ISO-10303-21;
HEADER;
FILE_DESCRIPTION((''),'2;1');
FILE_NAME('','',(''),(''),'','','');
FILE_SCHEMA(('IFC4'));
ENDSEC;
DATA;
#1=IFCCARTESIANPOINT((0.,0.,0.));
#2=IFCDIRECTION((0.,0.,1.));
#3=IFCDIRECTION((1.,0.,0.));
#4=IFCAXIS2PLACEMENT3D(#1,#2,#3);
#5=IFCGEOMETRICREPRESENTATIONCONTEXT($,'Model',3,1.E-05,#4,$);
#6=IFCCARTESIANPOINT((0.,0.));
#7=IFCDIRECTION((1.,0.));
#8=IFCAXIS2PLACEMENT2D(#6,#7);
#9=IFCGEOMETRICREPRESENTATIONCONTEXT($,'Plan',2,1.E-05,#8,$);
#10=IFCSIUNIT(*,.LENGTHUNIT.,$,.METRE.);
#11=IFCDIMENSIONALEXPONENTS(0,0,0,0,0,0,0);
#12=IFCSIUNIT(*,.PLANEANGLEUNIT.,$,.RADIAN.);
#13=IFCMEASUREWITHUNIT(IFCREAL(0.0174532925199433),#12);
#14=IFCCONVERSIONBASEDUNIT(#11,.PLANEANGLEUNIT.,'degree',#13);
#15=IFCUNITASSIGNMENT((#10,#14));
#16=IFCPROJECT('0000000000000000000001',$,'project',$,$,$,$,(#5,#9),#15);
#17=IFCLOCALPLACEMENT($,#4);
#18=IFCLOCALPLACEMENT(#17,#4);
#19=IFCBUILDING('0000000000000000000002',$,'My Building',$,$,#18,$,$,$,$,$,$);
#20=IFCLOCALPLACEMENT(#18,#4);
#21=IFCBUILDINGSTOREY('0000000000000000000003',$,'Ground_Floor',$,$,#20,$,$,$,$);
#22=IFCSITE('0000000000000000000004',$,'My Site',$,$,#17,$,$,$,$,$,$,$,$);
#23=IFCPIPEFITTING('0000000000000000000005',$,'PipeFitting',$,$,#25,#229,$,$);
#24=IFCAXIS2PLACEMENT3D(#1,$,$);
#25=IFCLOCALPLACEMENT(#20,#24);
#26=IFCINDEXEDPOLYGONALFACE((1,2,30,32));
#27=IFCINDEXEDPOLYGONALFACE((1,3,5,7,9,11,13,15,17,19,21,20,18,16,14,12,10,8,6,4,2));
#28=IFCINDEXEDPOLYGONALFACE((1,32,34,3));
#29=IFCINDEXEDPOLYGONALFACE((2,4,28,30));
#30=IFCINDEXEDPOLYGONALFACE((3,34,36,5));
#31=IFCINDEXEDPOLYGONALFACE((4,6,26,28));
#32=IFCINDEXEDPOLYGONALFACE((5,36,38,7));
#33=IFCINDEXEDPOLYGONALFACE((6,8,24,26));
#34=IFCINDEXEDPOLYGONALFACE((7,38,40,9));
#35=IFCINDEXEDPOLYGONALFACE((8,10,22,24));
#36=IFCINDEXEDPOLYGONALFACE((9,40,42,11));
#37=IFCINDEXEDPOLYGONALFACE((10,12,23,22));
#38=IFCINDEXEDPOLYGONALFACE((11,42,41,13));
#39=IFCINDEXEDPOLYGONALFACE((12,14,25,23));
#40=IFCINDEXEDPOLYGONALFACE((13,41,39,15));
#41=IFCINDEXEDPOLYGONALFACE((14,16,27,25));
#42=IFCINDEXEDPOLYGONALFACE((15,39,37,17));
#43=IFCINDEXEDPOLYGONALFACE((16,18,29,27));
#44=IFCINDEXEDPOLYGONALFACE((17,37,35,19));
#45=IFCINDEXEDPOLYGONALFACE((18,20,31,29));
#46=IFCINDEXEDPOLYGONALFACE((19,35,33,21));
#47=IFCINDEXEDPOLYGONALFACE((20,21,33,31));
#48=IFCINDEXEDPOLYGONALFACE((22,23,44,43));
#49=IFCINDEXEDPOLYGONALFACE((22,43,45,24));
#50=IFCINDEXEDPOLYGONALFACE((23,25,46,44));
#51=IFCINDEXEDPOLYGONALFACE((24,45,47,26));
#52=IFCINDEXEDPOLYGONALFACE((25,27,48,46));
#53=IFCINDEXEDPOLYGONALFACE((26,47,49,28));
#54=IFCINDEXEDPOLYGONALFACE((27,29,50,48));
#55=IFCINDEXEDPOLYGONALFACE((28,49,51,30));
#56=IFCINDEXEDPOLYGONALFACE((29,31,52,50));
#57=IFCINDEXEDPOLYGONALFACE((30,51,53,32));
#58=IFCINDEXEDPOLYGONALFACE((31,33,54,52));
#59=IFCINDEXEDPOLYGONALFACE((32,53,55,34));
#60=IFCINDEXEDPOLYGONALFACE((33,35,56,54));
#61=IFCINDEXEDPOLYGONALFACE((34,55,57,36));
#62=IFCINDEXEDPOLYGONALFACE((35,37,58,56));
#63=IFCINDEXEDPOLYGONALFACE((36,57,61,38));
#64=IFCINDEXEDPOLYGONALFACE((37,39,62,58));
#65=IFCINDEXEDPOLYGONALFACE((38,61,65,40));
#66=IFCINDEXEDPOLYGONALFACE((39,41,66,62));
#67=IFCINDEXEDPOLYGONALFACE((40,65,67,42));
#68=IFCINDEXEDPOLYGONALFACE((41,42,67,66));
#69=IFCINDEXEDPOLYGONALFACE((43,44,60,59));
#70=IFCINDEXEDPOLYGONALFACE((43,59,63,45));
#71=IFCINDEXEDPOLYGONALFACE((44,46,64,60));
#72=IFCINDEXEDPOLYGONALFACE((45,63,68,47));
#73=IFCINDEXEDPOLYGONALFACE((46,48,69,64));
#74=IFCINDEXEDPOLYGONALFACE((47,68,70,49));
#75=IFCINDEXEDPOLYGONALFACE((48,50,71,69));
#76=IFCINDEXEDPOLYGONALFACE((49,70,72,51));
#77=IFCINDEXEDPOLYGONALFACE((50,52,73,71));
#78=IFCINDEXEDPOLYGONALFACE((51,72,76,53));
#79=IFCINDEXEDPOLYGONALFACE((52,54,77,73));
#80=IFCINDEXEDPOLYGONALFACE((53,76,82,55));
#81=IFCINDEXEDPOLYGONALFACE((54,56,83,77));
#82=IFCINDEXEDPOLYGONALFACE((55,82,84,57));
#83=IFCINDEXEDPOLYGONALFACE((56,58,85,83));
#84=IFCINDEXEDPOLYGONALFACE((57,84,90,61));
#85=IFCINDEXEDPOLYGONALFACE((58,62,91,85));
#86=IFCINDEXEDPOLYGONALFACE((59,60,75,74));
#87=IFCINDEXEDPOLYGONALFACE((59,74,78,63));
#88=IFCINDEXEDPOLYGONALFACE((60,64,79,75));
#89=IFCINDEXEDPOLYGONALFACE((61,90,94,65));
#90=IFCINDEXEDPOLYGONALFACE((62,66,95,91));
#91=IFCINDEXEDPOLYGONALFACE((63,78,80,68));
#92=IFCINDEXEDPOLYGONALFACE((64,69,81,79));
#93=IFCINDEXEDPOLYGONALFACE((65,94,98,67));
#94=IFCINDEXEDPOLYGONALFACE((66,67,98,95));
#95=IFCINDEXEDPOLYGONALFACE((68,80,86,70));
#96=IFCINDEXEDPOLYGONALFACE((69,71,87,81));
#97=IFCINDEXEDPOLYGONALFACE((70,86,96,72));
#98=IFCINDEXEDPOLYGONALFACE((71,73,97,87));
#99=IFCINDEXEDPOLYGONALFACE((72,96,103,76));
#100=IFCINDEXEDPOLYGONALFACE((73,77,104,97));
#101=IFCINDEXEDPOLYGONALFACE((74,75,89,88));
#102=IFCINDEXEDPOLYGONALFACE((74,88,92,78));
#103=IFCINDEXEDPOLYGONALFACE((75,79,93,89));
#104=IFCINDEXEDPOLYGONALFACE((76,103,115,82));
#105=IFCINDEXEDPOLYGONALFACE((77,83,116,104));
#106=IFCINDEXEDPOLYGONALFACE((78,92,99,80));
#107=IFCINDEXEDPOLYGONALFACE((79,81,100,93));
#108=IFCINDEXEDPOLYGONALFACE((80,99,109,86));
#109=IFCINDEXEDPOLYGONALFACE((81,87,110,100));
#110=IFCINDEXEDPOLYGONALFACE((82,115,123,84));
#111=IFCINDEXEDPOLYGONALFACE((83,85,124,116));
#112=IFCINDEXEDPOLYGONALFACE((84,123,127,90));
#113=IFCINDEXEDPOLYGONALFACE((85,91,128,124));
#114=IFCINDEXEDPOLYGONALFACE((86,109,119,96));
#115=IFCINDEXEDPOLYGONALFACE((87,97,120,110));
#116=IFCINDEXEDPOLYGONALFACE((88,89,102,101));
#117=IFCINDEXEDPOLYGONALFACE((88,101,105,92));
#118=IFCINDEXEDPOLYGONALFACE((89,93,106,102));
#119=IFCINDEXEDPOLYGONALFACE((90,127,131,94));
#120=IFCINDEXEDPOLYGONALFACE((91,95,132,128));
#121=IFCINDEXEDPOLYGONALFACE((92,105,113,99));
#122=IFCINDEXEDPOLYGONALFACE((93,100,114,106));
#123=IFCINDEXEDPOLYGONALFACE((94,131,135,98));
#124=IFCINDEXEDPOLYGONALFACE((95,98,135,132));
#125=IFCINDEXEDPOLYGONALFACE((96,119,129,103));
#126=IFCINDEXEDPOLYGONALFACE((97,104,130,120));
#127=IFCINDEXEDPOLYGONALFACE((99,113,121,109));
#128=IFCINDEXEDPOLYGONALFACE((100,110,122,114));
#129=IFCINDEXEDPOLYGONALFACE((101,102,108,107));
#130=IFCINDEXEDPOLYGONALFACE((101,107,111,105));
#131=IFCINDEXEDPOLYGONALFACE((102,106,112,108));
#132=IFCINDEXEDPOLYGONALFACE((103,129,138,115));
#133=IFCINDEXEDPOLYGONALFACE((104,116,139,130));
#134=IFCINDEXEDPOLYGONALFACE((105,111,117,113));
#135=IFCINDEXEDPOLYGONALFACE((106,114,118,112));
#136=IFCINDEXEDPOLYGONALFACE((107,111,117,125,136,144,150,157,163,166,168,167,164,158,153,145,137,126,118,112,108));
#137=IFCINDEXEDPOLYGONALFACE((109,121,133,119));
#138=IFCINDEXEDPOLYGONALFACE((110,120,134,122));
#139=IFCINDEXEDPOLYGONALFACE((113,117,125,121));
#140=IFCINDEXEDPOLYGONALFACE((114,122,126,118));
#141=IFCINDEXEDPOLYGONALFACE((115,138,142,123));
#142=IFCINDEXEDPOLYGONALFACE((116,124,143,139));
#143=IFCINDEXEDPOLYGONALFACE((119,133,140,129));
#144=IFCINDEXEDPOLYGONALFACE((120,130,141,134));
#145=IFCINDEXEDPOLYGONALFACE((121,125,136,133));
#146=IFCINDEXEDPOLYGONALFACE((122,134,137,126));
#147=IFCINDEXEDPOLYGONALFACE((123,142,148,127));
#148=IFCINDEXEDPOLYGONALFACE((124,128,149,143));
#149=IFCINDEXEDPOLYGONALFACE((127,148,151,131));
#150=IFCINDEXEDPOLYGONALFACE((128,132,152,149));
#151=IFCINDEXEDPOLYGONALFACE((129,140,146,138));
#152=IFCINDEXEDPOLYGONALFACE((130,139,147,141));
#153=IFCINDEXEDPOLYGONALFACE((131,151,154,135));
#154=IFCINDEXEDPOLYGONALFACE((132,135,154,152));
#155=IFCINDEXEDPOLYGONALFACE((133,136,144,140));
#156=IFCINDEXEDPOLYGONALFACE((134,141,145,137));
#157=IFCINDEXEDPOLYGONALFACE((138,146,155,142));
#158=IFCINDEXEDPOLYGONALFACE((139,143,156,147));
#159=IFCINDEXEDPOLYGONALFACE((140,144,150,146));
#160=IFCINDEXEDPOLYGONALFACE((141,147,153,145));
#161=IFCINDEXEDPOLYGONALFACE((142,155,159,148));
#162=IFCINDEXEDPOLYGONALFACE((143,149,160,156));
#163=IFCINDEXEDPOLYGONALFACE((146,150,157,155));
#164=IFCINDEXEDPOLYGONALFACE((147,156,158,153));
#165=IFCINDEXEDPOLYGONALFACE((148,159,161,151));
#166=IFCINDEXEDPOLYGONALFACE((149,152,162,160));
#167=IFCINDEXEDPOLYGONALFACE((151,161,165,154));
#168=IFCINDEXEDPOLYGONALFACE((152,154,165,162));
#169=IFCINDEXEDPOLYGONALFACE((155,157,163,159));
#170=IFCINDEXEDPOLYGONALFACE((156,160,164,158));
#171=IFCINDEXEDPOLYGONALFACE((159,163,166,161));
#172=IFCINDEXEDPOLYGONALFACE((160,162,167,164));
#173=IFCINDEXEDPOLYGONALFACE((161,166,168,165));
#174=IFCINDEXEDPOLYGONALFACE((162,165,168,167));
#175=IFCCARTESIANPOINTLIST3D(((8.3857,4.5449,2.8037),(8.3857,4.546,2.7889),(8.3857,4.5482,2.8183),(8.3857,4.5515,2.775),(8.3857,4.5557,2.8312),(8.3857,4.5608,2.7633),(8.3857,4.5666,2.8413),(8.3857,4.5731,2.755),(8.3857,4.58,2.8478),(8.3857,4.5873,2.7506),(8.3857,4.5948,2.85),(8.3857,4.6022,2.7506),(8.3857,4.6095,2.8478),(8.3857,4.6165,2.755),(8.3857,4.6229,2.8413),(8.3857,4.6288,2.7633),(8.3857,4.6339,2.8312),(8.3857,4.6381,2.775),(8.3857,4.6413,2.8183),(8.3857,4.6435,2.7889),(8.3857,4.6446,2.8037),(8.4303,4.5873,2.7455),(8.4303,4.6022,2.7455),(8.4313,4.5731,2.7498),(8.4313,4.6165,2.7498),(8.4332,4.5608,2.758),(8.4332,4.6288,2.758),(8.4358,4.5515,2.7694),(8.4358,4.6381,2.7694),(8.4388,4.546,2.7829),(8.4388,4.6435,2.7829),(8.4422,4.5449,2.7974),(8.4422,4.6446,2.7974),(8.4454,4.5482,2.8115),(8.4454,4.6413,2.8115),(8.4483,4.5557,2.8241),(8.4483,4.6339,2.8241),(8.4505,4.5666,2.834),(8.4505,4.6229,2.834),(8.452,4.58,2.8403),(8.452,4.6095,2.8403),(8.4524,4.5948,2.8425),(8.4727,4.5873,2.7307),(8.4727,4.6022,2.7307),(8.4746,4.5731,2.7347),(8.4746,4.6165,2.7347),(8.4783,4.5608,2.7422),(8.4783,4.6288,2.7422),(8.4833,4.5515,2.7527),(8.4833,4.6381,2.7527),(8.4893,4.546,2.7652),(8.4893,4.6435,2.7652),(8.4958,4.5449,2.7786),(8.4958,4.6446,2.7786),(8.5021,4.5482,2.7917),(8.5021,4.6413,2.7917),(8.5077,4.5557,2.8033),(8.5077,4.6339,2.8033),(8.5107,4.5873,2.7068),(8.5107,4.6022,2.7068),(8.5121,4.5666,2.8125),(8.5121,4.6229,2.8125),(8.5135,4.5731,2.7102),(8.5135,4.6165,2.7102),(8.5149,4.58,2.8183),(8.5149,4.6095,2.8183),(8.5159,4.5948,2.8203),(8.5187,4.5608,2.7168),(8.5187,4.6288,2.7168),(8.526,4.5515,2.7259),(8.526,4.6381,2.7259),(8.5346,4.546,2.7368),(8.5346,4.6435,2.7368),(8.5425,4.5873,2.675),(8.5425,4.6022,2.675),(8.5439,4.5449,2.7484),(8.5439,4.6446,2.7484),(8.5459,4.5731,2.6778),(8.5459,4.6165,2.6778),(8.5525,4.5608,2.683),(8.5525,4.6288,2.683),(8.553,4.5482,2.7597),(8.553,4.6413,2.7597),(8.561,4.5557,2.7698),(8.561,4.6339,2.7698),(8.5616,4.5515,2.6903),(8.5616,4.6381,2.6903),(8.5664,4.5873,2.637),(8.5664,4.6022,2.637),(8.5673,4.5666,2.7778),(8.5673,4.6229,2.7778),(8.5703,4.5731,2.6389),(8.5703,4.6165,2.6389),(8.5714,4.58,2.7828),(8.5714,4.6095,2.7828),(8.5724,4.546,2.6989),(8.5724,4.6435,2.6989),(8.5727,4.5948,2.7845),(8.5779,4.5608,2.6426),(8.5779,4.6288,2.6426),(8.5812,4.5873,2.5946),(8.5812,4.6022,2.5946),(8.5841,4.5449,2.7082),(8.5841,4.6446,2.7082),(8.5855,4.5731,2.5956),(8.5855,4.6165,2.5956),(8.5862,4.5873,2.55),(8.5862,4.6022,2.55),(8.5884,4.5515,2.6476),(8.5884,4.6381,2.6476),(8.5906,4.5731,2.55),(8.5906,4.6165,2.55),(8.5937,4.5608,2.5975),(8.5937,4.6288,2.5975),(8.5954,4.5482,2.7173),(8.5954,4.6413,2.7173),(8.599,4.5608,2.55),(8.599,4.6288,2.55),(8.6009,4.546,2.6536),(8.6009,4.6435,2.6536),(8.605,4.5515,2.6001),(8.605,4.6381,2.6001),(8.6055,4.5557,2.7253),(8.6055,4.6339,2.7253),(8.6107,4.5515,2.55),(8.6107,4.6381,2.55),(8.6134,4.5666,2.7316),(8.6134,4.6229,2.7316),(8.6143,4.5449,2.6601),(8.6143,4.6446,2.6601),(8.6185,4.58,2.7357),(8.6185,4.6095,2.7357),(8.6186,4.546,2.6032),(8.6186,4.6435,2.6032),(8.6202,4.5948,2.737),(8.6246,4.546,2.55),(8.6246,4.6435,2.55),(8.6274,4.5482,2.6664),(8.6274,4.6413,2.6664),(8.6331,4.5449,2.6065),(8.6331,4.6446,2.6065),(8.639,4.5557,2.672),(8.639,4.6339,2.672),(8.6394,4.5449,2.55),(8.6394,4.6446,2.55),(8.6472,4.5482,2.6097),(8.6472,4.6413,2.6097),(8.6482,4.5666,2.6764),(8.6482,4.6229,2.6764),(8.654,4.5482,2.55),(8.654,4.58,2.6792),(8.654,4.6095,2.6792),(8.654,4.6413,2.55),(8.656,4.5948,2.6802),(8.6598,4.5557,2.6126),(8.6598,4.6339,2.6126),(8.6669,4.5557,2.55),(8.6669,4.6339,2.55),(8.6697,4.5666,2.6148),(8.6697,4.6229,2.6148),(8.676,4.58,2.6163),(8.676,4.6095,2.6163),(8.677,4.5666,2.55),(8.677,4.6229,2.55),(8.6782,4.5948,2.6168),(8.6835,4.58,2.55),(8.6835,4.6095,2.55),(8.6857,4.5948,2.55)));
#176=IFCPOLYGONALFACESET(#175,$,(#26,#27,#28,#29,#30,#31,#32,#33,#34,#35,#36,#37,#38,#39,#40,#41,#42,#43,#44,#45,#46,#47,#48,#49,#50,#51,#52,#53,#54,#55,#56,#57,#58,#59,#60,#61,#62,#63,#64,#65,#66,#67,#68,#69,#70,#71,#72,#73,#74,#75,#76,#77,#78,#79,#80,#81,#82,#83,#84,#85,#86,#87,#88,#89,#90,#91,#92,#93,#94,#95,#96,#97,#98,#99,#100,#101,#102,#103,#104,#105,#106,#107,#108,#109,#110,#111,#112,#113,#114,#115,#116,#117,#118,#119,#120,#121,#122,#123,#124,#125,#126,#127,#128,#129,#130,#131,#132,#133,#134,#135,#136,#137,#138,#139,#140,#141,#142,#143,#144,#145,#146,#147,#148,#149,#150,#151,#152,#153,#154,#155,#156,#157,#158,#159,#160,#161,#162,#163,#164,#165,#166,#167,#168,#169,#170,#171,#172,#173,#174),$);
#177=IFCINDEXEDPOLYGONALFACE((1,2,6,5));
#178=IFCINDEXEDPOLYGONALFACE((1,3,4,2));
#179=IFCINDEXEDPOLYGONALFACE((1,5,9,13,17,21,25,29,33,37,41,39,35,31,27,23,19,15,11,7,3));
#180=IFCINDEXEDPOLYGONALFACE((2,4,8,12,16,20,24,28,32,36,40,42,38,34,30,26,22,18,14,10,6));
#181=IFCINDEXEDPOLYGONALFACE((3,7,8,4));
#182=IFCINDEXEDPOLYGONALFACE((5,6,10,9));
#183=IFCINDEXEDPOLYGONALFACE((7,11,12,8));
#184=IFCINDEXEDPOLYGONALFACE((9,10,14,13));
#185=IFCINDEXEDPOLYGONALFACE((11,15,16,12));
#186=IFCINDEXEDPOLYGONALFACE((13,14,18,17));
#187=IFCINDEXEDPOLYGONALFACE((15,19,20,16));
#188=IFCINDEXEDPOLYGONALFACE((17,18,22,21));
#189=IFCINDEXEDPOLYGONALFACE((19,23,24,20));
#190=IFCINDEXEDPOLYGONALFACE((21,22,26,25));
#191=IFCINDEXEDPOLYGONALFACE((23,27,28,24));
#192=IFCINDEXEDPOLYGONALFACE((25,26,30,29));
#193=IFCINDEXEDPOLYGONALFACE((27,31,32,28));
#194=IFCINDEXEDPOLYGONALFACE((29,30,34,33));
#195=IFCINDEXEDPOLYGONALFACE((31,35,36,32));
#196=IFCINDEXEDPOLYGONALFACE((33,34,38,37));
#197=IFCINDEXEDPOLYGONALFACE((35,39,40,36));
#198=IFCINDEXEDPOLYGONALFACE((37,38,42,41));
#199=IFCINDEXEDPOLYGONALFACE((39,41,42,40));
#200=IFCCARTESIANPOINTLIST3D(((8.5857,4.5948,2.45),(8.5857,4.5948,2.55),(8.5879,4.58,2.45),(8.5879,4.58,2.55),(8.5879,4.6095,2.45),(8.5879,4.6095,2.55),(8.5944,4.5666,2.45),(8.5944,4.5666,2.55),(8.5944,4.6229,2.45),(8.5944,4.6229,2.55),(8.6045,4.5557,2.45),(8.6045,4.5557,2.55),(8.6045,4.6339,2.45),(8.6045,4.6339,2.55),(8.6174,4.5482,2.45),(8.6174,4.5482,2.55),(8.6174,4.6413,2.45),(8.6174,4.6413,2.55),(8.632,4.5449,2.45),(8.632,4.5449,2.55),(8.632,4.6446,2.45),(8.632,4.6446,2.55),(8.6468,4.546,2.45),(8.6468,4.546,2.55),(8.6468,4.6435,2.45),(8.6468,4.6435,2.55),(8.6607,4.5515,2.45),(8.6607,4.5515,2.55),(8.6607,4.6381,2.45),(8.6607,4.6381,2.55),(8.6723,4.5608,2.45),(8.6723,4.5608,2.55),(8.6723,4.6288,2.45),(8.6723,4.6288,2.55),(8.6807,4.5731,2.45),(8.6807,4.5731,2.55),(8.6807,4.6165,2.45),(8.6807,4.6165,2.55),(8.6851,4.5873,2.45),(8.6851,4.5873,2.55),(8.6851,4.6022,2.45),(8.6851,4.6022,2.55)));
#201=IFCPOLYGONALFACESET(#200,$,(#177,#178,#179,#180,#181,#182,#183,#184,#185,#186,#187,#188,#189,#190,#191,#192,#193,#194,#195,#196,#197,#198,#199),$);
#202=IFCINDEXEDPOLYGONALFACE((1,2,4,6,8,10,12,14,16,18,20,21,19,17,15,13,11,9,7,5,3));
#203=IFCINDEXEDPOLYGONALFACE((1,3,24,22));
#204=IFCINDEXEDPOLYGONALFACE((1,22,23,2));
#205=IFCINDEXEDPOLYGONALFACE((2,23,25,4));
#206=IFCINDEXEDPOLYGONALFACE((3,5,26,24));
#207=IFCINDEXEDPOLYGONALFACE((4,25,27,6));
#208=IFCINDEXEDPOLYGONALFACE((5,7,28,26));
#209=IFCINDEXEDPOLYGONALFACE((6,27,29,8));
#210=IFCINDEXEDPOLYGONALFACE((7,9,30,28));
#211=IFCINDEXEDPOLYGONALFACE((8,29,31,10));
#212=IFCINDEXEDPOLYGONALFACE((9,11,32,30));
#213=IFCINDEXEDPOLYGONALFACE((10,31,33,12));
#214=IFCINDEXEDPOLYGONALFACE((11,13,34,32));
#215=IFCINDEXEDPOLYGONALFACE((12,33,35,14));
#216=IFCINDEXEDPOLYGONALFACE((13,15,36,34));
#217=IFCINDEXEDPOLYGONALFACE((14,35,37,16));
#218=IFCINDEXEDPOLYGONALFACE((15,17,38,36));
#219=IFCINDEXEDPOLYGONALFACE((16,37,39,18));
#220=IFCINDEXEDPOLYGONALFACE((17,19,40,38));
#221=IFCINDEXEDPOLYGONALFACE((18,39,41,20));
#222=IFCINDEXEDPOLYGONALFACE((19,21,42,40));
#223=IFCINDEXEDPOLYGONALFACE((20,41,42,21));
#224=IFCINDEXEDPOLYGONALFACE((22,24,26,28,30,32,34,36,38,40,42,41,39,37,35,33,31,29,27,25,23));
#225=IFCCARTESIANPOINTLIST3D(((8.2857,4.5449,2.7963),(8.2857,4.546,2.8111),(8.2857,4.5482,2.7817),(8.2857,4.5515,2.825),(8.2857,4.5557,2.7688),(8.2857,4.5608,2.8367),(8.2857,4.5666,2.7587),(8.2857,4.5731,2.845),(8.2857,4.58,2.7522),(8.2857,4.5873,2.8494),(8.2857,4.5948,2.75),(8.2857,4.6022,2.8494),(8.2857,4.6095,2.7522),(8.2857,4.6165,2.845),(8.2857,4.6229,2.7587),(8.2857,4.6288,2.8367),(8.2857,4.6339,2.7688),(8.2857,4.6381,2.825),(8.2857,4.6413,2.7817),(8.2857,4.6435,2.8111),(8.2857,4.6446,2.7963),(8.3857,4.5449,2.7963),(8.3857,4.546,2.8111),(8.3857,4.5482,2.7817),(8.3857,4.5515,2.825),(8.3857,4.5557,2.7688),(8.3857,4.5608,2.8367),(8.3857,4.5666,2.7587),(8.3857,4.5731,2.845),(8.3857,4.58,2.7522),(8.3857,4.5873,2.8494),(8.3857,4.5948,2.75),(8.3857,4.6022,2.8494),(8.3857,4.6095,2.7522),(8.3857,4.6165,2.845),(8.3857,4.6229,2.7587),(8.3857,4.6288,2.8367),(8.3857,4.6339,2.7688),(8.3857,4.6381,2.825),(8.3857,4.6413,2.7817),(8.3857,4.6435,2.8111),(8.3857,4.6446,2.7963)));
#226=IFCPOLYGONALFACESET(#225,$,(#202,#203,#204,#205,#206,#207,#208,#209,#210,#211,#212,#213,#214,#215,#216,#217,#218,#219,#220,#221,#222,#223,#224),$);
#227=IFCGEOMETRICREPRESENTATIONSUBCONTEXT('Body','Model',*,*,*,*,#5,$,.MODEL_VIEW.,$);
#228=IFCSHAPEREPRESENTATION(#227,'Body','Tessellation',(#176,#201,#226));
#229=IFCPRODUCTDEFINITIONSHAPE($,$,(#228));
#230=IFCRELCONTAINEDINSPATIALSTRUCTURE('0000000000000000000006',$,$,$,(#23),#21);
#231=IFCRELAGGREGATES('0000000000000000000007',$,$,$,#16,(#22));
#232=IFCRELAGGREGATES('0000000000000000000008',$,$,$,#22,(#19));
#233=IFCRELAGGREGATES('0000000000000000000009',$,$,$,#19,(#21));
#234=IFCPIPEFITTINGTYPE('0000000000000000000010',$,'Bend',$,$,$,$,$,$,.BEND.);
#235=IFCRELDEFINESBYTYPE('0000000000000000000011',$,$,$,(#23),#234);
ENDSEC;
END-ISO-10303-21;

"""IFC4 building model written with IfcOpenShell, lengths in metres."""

from ifc_helpers import new_model, entity, si_unit, converted_unit, frame, origin_with_axes, origin_2d_with_axis, place, context, subcontext, project, spatial, circle, extrude, source, transform, mapped, type_object, type_shapes, element, save


model = new_model("IFC4")

# Units and contexts
model_context = context("Model", 3, precision=1e-05, world=origin_with_axes())
plan_context = context("Plan", 2, precision=1e-05, world=origin_2d_with_axis())
body_context = subcontext(model_context, "Body", "Model", "MODEL_VIEW")
ifc_project = project(units=[si_unit("LENGTHUNIT", "METRE"), converted_unit("PLANEANGLEUNIT", "degree", entity("IfcReal", 0.0174532925199433), si_unit("PLANEANGLEUNIT", "RADIAN"), dimensions=[0, 0, 0, 0, 0, 0, 0])], contexts=[model_context, plan_context])

# Site, building, storey
site_placement = place(None, origin_with_axes())
site = spatial("IfcSite", under=ifc_project, at=site_placement, Name="My Site")
building_placement = place(site_placement, origin_with_axes())
building = spatial("IfcBuilding", under=site, at=building_placement, Name="My Building")
storey_placement = place(building_placement, origin_with_axes())
storey = spatial("IfcBuildingStorey", under=building, at=storey_placement, Name="Ground_Floor")

# Pipe fitting
pipe_fitting_type = type_object("IfcPipeFittingType", Name="Bend", PredefinedType="BEND")
shared_shape = source(origin_with_axes(), body_context, "Body", "SolidModel", [
    entity("IfcSweptDiskSolid", entity("IfcIndexedPolyCurve", entity("IfcCartesianPointList3D", [[0.0, 0.0, -0.1], [0.0732, 0.0, -0.2768], [0.25, 0.0, -0.35]]), [entity("IfcArcIndex", [1, 2, 3])]), 0.05),
    extrude(circle(Radius=0.05), origin_with_axes(), (0.0, 0.0, -1.0), 0.1),
    extrude(circle(Radius=0.05), frame((0.25, 0.0, -0.35), z_axis=(1.0, 0.0, 0.0), x_axis=(0.0, 0.0, 1.0)), (0.0, 0.0, 1.0), 0.1),
])
type_shapes(pipe_fitting_type, [shared_shape])
for number, where, z_axis, x_axis, name in (
    (1, (8.6357, 4.5948, 2.45), (0.0, 0.0, -1.0), (-1.0, 0.0, 0.0), "PipeFitting"),
):
    element("IfcPipeFitting", number, at=place(storey_placement, frame(where, z_axis=z_axis, x_axis=x_axis)), inside=storey, type_object=pipe_fitting_type, Name=name, context=body_context, shape_type="MappedRepresentation", body=[
        mapped(shared_shape, transform((0.0, 0.0, 0.0), x_axis=(1.0, 0.0, 0.0), y_axis=(0.0, 1.0, 0.0), z_axis=(0.0, 0.0, 1.0), scale=1.0)),
    ])

save(model, "model.ifc")
